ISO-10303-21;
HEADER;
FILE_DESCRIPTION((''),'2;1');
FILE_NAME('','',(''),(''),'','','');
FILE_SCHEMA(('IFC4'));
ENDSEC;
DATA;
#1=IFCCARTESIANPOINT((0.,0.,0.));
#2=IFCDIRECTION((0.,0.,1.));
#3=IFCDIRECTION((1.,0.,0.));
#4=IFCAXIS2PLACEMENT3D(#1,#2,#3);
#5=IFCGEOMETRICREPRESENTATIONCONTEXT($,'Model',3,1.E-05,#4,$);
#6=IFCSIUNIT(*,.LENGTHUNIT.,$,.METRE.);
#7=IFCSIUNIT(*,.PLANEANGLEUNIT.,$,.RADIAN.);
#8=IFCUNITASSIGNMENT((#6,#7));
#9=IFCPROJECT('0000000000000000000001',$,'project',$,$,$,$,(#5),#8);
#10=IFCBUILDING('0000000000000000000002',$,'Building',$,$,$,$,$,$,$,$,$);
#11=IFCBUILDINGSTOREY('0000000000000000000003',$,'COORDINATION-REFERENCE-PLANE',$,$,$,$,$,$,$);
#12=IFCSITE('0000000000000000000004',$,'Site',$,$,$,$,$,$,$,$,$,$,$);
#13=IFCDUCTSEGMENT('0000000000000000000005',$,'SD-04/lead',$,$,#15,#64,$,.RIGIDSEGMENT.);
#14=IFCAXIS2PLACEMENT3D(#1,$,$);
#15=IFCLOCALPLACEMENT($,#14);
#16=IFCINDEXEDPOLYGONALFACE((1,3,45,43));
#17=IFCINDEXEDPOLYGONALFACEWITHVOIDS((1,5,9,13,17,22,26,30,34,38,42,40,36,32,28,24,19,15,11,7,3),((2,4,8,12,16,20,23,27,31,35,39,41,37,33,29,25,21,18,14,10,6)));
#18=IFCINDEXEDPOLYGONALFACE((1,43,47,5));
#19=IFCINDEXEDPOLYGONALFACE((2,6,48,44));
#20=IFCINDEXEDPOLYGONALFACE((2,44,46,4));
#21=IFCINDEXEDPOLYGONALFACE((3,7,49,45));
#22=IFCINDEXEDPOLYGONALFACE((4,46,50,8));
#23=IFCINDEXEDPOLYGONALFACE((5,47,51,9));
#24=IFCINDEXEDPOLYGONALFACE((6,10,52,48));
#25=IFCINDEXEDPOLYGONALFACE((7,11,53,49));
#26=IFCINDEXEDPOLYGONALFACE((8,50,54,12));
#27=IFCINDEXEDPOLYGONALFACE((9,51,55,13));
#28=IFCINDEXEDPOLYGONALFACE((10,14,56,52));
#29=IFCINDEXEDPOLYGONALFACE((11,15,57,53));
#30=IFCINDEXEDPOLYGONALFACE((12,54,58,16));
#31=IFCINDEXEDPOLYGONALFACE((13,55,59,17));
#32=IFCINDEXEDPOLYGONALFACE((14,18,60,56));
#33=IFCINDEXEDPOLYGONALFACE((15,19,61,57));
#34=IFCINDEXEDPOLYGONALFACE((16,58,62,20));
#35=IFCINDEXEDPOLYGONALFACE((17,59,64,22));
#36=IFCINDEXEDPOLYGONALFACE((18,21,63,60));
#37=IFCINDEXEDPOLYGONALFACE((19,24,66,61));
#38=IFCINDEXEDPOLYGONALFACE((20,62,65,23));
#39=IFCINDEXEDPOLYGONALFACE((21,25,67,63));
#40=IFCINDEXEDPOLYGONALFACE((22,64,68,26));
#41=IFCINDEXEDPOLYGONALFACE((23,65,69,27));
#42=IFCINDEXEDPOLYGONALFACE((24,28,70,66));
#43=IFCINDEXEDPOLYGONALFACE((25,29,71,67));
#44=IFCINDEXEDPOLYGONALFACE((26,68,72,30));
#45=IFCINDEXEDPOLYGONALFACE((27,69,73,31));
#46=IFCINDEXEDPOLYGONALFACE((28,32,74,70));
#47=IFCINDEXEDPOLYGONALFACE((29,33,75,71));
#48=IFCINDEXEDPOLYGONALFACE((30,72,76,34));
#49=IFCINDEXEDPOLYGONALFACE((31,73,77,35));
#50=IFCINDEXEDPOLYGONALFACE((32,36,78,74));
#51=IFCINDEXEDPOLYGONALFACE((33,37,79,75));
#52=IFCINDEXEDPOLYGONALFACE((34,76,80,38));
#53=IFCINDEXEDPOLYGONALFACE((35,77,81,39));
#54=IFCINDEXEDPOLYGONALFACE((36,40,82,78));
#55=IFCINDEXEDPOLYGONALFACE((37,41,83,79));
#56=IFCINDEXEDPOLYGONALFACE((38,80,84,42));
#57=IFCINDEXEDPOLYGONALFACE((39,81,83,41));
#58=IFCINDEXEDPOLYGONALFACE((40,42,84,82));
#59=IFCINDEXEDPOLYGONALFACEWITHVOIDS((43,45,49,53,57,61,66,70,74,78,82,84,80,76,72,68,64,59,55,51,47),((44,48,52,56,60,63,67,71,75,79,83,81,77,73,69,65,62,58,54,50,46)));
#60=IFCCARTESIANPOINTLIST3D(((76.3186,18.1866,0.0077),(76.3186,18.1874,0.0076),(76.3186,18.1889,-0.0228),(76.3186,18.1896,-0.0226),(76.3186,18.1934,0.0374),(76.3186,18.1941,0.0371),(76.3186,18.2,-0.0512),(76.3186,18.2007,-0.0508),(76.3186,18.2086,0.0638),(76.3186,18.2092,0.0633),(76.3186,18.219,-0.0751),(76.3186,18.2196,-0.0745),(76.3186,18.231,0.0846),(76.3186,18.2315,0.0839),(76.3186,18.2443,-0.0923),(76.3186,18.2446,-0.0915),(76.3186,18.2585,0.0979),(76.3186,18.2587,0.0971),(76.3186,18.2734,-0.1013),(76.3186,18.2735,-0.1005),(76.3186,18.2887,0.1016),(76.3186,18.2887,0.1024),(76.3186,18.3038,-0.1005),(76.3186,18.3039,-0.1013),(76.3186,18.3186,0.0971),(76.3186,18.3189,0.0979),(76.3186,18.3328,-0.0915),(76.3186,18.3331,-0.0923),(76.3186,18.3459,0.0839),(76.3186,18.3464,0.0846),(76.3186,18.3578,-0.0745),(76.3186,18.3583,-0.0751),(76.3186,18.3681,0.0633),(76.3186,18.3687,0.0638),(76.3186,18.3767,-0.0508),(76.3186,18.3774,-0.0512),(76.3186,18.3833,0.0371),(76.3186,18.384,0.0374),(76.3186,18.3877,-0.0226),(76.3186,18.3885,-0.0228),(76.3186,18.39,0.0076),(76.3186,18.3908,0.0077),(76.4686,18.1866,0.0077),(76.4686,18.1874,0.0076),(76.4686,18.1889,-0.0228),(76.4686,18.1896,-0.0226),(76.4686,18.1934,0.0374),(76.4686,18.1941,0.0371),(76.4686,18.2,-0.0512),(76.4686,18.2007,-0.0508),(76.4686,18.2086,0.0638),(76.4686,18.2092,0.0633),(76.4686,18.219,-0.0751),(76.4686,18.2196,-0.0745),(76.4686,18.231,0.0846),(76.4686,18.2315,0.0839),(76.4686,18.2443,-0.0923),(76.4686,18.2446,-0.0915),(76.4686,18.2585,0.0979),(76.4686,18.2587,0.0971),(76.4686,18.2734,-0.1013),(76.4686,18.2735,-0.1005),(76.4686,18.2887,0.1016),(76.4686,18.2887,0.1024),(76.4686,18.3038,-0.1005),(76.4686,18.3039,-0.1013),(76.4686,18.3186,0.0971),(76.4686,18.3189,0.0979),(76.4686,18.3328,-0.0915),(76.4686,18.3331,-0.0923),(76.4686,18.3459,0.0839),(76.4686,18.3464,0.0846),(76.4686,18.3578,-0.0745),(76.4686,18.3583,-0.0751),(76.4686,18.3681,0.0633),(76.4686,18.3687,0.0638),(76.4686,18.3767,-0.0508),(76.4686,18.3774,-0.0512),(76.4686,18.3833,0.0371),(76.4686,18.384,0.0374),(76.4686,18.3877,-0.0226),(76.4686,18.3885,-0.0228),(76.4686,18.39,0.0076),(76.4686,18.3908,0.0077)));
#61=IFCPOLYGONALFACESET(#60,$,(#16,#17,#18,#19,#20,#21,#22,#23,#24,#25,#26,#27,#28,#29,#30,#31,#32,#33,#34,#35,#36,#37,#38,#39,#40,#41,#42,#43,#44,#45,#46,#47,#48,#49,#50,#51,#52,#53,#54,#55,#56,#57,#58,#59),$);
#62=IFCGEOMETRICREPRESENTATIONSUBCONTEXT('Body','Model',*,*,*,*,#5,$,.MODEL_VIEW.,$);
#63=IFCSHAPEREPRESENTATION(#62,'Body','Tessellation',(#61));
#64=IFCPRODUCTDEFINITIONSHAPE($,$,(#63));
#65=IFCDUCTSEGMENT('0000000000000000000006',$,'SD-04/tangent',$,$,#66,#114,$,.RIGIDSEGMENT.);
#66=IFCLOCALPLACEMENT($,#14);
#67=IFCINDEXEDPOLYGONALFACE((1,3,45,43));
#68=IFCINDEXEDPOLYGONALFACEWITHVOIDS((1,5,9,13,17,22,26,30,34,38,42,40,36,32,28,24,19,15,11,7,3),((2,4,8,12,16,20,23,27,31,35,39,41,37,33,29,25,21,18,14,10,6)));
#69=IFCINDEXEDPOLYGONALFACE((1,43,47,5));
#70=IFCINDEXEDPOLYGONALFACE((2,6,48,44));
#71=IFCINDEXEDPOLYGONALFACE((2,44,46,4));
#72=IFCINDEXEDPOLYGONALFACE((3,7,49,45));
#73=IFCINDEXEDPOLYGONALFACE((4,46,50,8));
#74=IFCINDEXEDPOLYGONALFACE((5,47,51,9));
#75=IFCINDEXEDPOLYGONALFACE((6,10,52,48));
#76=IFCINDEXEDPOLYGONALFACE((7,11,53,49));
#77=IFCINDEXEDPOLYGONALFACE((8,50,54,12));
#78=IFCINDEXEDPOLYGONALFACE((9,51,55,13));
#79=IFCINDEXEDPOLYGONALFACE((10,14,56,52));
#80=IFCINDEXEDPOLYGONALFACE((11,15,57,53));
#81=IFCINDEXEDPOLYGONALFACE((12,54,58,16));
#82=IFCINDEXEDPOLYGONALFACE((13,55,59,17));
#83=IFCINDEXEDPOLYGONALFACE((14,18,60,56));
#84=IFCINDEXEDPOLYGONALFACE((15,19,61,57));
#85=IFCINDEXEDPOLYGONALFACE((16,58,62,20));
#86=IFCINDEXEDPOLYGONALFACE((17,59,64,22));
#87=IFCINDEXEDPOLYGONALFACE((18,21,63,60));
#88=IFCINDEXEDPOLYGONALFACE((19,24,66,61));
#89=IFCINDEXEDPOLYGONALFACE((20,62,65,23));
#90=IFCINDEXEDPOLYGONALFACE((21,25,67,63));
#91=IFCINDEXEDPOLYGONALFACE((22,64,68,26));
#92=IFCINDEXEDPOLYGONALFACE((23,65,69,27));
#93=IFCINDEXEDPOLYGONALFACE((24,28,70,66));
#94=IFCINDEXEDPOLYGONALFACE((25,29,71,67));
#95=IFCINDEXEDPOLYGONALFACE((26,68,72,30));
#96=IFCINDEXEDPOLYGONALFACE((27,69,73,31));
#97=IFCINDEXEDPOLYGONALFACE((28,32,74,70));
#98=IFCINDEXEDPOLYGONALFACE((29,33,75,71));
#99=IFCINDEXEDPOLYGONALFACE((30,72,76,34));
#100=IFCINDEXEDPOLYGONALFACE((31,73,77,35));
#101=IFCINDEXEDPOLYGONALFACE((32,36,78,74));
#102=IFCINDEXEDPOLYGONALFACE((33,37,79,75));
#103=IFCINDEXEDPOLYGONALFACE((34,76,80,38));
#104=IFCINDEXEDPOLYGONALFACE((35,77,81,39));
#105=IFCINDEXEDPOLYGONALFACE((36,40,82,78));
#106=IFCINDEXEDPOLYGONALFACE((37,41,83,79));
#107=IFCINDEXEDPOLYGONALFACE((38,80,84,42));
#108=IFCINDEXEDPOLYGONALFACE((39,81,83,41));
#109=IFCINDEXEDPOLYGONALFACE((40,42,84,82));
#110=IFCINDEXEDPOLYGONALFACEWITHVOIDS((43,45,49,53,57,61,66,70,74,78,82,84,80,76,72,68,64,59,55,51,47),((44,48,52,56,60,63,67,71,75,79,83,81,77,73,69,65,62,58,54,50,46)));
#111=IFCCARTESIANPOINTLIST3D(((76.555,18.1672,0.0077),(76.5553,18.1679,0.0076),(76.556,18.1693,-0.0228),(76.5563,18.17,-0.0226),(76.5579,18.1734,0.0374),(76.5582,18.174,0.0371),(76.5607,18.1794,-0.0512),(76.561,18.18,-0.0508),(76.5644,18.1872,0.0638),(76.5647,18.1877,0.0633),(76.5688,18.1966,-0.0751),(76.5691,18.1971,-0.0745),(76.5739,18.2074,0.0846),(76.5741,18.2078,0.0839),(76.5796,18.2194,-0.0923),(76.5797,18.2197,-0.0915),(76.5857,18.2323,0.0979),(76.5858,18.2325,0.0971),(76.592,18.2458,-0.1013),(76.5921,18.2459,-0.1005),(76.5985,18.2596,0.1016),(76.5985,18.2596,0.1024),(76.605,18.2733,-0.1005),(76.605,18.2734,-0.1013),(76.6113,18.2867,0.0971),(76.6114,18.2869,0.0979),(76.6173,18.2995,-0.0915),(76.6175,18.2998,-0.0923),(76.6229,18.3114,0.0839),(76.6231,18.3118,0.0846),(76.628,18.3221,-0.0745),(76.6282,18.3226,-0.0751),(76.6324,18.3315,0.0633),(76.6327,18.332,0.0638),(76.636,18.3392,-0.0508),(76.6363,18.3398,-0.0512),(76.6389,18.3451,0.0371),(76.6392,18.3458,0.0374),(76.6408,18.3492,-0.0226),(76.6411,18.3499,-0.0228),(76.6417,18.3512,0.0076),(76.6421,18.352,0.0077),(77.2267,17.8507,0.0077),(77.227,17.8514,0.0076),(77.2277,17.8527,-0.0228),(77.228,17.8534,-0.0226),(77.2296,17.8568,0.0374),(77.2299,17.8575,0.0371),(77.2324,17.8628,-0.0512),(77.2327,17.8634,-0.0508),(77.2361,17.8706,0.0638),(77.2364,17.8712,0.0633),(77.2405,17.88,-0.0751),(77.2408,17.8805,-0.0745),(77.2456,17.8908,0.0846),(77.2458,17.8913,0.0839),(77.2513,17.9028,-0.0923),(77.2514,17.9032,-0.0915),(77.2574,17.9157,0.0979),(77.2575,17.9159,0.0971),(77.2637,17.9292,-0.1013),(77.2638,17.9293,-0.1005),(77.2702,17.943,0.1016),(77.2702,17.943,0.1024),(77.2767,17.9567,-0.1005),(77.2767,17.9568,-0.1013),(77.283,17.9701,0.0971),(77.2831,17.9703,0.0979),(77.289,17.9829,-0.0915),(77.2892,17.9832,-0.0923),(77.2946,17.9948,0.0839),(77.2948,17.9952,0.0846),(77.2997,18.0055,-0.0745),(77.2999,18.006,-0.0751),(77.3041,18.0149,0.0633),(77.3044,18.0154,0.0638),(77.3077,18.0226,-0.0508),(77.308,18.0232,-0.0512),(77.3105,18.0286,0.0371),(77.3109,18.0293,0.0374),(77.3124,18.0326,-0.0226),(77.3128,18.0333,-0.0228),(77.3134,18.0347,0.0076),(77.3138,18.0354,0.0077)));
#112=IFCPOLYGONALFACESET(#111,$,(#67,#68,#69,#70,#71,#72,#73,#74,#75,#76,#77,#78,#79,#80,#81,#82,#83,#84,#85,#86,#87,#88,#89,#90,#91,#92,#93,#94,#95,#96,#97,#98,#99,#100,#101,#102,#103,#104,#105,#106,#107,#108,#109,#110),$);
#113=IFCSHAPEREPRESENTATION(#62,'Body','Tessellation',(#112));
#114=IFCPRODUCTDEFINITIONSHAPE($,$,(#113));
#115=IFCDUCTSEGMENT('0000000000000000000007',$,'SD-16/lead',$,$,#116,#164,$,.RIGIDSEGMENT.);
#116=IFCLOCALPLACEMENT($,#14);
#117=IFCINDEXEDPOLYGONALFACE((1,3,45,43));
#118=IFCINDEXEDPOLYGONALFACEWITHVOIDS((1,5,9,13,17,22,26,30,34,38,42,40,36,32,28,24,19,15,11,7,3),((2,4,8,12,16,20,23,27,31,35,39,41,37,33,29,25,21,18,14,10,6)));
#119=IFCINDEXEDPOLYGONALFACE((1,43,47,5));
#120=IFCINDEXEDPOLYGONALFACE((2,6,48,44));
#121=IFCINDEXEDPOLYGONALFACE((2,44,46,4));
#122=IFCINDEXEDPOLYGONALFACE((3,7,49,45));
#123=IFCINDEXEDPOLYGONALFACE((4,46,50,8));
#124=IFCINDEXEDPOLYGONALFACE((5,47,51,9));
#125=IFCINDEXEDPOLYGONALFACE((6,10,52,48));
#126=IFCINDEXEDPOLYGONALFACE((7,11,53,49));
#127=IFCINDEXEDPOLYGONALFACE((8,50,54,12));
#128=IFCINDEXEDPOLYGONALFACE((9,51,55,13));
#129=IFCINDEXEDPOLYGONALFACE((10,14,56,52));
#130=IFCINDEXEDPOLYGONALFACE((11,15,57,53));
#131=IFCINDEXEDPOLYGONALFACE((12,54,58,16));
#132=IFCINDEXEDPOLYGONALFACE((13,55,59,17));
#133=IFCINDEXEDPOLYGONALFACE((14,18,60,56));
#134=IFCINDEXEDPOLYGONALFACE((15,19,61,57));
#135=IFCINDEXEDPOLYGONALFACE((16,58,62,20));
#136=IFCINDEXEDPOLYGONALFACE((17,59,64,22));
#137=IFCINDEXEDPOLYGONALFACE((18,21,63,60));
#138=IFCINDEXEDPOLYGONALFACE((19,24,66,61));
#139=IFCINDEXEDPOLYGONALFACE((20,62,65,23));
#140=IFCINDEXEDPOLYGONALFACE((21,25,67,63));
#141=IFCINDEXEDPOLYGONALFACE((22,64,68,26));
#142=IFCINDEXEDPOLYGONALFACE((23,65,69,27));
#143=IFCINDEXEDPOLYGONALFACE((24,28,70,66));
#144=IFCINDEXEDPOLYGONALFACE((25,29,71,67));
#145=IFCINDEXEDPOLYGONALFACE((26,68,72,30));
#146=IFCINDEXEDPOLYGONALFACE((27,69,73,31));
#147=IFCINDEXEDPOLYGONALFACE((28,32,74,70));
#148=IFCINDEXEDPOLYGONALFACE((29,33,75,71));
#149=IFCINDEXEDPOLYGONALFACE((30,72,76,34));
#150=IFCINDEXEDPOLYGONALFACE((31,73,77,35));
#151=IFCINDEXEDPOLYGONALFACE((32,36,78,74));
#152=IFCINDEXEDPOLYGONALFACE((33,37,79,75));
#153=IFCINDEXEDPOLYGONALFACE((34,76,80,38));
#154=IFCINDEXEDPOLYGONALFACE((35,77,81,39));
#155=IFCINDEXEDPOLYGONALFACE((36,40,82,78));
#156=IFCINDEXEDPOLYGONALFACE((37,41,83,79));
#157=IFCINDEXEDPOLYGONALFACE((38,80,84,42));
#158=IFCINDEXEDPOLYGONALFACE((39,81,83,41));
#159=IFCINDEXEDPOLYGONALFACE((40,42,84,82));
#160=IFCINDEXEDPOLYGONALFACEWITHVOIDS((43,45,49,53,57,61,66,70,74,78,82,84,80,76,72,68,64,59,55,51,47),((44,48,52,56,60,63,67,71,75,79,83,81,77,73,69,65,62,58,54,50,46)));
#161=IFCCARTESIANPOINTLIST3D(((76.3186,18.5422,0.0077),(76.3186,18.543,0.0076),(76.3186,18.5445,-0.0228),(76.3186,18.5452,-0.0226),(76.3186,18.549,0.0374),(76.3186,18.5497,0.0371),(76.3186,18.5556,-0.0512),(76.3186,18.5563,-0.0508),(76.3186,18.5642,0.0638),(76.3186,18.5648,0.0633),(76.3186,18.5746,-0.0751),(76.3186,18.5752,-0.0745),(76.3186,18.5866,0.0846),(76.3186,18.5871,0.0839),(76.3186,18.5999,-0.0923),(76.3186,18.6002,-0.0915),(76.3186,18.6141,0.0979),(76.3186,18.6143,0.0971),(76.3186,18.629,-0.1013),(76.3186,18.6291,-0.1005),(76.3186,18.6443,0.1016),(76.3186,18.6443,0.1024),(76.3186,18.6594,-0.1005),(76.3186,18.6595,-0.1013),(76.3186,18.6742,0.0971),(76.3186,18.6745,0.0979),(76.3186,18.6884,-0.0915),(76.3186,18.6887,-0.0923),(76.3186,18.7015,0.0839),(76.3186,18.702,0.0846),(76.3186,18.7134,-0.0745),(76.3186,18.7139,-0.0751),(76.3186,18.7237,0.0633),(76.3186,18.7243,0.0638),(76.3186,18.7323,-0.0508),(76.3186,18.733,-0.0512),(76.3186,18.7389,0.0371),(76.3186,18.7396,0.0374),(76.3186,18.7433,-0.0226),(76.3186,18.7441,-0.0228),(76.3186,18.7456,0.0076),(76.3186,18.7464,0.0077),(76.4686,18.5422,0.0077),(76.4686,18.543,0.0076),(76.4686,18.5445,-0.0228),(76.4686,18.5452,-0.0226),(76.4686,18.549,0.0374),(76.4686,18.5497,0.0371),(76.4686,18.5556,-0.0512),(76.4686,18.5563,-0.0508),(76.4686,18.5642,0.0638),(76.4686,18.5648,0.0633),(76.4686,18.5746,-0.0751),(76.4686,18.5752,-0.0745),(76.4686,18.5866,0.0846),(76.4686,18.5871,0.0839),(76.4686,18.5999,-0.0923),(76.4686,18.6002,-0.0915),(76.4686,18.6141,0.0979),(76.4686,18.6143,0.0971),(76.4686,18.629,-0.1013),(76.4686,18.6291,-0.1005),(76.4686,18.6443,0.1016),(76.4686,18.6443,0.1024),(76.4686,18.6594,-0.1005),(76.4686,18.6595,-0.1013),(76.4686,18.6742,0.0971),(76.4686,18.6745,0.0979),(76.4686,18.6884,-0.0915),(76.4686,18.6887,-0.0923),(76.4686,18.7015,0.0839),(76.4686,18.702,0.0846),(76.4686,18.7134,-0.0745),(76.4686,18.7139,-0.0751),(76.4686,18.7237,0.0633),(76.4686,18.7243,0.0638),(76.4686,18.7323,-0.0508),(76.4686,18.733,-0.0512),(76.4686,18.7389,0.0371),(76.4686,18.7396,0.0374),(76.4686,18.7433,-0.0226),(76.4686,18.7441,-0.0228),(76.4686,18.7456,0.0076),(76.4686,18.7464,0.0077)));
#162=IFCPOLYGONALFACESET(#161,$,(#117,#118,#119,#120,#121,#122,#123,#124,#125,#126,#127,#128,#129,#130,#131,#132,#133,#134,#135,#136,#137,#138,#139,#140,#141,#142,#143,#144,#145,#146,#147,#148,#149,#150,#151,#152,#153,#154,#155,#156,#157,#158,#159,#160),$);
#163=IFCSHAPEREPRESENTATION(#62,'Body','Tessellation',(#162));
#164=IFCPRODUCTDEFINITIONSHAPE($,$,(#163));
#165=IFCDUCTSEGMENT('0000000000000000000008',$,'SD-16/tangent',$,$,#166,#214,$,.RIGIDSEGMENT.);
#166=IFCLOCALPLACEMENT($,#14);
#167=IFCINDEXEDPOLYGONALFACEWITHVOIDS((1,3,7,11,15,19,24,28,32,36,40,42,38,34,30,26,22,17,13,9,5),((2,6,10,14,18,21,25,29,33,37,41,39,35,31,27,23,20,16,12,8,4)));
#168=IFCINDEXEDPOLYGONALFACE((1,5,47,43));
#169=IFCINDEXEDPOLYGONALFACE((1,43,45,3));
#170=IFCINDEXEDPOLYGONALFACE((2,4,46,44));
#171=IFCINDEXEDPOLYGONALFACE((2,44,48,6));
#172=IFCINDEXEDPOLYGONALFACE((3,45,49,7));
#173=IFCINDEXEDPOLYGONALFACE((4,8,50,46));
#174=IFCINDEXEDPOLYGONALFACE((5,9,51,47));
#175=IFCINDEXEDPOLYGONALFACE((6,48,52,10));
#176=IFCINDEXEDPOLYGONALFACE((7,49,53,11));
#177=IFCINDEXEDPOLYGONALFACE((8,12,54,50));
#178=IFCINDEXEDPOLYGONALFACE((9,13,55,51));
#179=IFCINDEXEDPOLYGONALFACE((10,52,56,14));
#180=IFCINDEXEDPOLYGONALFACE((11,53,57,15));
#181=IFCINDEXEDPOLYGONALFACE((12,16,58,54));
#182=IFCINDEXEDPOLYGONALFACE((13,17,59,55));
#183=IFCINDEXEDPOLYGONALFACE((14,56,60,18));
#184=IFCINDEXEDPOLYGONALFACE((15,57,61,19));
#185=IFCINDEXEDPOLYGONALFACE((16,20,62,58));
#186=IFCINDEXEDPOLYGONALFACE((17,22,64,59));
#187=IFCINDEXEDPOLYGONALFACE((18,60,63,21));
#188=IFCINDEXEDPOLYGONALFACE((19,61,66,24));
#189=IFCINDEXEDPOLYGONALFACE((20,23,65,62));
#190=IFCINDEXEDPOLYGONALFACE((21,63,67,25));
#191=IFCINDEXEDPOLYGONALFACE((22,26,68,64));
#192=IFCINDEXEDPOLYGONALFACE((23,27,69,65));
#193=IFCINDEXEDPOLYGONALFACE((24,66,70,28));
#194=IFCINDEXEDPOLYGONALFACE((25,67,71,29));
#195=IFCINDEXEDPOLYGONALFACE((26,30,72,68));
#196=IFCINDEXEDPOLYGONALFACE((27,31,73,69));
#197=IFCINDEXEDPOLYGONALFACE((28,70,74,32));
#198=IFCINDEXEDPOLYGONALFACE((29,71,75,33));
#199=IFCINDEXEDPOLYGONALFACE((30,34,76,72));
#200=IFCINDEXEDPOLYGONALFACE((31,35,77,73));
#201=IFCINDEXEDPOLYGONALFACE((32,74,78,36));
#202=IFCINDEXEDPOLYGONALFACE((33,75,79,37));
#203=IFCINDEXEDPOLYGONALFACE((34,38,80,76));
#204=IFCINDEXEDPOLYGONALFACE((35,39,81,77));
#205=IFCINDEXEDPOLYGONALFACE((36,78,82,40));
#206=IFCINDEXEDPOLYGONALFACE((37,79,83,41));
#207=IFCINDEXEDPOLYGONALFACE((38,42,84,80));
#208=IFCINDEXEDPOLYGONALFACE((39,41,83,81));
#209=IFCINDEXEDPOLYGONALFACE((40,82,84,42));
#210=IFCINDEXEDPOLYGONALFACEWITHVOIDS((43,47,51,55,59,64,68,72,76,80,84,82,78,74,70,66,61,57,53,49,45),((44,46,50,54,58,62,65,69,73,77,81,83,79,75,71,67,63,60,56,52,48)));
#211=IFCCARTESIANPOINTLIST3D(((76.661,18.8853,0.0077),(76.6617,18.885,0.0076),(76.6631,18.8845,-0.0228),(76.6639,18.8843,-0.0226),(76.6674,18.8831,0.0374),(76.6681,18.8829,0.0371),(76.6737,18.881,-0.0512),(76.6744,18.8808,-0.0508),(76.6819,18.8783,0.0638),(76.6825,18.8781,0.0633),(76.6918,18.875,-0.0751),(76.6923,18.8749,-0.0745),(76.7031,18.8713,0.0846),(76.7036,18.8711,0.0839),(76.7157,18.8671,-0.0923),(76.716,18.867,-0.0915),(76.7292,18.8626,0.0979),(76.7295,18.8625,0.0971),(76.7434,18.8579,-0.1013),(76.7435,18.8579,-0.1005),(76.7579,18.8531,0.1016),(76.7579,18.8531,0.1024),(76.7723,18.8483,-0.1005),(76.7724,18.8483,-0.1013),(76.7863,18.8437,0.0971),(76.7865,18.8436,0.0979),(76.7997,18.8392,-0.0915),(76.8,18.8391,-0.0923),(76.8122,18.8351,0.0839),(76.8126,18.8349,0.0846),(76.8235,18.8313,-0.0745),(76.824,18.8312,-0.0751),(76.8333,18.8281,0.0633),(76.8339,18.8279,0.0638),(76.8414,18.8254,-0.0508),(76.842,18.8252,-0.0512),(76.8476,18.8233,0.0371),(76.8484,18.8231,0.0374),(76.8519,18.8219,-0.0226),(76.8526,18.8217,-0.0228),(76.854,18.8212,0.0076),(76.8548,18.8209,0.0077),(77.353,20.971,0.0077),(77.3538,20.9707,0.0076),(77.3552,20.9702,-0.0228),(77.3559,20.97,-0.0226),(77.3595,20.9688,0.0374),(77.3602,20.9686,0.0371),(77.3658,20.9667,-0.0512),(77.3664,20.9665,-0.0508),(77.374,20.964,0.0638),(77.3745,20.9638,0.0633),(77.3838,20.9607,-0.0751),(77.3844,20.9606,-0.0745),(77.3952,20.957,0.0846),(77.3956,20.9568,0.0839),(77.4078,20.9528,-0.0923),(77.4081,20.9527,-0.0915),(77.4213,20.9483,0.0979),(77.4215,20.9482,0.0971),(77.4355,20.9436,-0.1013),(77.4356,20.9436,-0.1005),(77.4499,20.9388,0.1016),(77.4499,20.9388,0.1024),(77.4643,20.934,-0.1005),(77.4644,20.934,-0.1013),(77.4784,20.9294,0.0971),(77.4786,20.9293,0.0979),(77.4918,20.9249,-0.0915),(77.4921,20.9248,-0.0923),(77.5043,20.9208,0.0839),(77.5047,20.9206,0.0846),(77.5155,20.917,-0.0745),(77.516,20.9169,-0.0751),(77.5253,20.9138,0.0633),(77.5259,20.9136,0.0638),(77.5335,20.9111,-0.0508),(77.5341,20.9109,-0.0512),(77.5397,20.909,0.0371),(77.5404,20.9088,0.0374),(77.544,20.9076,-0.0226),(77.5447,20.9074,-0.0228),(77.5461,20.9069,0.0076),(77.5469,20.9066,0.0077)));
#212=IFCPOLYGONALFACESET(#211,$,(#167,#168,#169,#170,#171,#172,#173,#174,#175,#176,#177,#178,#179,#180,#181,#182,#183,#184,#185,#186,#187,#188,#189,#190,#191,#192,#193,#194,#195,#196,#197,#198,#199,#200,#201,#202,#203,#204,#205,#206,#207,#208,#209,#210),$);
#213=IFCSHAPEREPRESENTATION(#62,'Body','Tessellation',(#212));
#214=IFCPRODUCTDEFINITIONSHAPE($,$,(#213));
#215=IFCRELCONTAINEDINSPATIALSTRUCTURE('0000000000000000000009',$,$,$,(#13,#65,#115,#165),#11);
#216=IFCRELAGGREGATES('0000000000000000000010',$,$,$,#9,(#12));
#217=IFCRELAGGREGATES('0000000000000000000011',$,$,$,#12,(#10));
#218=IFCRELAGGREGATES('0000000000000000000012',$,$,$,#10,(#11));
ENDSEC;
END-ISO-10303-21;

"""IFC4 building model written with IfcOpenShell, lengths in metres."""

from ifc_helpers import new_model, si_unit, frame, origin_with_axes, place, context, subcontext, project, spatial, hollow_circle, extrude, element, save


model = new_model("IFC4")

# Units and contexts
model_context = context("Model", 3, precision=1e-05, world=origin_with_axes())
body_context_1 = subcontext(model_context, "Body", "Model", "MODEL_VIEW")
ifc_project = project(units=[si_unit("LENGTHUNIT", "METRE"), si_unit("PLANEANGLEUNIT", "RADIAN")], contexts=[model_context])

# Site, building, storey
site = spatial("IfcSite", under=ifc_project, Name="Site")
building = spatial("IfcBuilding", under=site, Name="Building")
storey = spatial("IfcBuildingStorey", under=building, Name="COORDINATION-REFERENCE-PLANE")

# Duct segment
duct_segment_1_placement = place(None, frame((76.3186, 18.2887, 0.0), z_axis=(1.0, 0.0, 0.0), x_axis=(0.0, 0.0, 1.0)))
element("IfcDuctSegment", 1, at=duct_segment_1_placement, inside=storey, Name="SD-04/lead", PredefinedType="RIGIDSEGMENT", context=body_context_1, shape_type="SweptSolid", body=[
    extrude(hollow_circle(Radius=0.1024, WallThickness=0.0008), origin_with_axes(), (0.0, 0.0, 1.0), 0.15),
])

# Duct segment
duct_segment_2_placement = place(None, frame((76.5985, 18.2596, 0.0), z_axis=(0.904569, -0.426327, 0.0), x_axis=(0.0, 0.0, 1.0)))
element("IfcDuctSegment", 2, at=duct_segment_2_placement, inside=storey, Name="SD-04/tangent", PredefinedType="RIGIDSEGMENT", context=body_context_1, shape_type="SweptSolid", body=[
    extrude(hollow_circle(Radius=0.1024, WallThickness=0.0008), origin_with_axes(), (0.0, 0.0, 1.0), 0.7425),
])

# Duct segment
duct_segment_3_placement = place(None, frame((76.3186, 18.6443, 0.0), z_axis=(1.0, 0.0, 0.0), x_axis=(0.0, 0.0, 1.0)))
element("IfcDuctSegment", 3, at=duct_segment_3_placement, inside=storey, Name="SD-16/lead", PredefinedType="RIGIDSEGMENT", context=body_context_1, shape_type="SweptSolid", body=[
    extrude(hollow_circle(Radius=0.1024, WallThickness=0.0008), origin_with_axes(), (0.0, 0.0, 1.0), 0.15),
])

# Duct segment
duct_segment_4_placement = place(None, frame((76.7579, 18.8531, 0.0), z_axis=(0.314929, 0.949115, 0.0), x_axis=(0.0, 0.0, 1.0)))
element("IfcDuctSegment", 4, at=duct_segment_4_placement, inside=storey, Name="SD-16/tangent", PredefinedType="RIGIDSEGMENT", context=body_context_1, shape_type="SweptSolid", body=[
    extrude(hollow_circle(Radius=0.1024, WallThickness=0.0008), origin_with_axes(), (0.0, 0.0, 1.0), 2.1975),
])

save(model, "model.ifc")
